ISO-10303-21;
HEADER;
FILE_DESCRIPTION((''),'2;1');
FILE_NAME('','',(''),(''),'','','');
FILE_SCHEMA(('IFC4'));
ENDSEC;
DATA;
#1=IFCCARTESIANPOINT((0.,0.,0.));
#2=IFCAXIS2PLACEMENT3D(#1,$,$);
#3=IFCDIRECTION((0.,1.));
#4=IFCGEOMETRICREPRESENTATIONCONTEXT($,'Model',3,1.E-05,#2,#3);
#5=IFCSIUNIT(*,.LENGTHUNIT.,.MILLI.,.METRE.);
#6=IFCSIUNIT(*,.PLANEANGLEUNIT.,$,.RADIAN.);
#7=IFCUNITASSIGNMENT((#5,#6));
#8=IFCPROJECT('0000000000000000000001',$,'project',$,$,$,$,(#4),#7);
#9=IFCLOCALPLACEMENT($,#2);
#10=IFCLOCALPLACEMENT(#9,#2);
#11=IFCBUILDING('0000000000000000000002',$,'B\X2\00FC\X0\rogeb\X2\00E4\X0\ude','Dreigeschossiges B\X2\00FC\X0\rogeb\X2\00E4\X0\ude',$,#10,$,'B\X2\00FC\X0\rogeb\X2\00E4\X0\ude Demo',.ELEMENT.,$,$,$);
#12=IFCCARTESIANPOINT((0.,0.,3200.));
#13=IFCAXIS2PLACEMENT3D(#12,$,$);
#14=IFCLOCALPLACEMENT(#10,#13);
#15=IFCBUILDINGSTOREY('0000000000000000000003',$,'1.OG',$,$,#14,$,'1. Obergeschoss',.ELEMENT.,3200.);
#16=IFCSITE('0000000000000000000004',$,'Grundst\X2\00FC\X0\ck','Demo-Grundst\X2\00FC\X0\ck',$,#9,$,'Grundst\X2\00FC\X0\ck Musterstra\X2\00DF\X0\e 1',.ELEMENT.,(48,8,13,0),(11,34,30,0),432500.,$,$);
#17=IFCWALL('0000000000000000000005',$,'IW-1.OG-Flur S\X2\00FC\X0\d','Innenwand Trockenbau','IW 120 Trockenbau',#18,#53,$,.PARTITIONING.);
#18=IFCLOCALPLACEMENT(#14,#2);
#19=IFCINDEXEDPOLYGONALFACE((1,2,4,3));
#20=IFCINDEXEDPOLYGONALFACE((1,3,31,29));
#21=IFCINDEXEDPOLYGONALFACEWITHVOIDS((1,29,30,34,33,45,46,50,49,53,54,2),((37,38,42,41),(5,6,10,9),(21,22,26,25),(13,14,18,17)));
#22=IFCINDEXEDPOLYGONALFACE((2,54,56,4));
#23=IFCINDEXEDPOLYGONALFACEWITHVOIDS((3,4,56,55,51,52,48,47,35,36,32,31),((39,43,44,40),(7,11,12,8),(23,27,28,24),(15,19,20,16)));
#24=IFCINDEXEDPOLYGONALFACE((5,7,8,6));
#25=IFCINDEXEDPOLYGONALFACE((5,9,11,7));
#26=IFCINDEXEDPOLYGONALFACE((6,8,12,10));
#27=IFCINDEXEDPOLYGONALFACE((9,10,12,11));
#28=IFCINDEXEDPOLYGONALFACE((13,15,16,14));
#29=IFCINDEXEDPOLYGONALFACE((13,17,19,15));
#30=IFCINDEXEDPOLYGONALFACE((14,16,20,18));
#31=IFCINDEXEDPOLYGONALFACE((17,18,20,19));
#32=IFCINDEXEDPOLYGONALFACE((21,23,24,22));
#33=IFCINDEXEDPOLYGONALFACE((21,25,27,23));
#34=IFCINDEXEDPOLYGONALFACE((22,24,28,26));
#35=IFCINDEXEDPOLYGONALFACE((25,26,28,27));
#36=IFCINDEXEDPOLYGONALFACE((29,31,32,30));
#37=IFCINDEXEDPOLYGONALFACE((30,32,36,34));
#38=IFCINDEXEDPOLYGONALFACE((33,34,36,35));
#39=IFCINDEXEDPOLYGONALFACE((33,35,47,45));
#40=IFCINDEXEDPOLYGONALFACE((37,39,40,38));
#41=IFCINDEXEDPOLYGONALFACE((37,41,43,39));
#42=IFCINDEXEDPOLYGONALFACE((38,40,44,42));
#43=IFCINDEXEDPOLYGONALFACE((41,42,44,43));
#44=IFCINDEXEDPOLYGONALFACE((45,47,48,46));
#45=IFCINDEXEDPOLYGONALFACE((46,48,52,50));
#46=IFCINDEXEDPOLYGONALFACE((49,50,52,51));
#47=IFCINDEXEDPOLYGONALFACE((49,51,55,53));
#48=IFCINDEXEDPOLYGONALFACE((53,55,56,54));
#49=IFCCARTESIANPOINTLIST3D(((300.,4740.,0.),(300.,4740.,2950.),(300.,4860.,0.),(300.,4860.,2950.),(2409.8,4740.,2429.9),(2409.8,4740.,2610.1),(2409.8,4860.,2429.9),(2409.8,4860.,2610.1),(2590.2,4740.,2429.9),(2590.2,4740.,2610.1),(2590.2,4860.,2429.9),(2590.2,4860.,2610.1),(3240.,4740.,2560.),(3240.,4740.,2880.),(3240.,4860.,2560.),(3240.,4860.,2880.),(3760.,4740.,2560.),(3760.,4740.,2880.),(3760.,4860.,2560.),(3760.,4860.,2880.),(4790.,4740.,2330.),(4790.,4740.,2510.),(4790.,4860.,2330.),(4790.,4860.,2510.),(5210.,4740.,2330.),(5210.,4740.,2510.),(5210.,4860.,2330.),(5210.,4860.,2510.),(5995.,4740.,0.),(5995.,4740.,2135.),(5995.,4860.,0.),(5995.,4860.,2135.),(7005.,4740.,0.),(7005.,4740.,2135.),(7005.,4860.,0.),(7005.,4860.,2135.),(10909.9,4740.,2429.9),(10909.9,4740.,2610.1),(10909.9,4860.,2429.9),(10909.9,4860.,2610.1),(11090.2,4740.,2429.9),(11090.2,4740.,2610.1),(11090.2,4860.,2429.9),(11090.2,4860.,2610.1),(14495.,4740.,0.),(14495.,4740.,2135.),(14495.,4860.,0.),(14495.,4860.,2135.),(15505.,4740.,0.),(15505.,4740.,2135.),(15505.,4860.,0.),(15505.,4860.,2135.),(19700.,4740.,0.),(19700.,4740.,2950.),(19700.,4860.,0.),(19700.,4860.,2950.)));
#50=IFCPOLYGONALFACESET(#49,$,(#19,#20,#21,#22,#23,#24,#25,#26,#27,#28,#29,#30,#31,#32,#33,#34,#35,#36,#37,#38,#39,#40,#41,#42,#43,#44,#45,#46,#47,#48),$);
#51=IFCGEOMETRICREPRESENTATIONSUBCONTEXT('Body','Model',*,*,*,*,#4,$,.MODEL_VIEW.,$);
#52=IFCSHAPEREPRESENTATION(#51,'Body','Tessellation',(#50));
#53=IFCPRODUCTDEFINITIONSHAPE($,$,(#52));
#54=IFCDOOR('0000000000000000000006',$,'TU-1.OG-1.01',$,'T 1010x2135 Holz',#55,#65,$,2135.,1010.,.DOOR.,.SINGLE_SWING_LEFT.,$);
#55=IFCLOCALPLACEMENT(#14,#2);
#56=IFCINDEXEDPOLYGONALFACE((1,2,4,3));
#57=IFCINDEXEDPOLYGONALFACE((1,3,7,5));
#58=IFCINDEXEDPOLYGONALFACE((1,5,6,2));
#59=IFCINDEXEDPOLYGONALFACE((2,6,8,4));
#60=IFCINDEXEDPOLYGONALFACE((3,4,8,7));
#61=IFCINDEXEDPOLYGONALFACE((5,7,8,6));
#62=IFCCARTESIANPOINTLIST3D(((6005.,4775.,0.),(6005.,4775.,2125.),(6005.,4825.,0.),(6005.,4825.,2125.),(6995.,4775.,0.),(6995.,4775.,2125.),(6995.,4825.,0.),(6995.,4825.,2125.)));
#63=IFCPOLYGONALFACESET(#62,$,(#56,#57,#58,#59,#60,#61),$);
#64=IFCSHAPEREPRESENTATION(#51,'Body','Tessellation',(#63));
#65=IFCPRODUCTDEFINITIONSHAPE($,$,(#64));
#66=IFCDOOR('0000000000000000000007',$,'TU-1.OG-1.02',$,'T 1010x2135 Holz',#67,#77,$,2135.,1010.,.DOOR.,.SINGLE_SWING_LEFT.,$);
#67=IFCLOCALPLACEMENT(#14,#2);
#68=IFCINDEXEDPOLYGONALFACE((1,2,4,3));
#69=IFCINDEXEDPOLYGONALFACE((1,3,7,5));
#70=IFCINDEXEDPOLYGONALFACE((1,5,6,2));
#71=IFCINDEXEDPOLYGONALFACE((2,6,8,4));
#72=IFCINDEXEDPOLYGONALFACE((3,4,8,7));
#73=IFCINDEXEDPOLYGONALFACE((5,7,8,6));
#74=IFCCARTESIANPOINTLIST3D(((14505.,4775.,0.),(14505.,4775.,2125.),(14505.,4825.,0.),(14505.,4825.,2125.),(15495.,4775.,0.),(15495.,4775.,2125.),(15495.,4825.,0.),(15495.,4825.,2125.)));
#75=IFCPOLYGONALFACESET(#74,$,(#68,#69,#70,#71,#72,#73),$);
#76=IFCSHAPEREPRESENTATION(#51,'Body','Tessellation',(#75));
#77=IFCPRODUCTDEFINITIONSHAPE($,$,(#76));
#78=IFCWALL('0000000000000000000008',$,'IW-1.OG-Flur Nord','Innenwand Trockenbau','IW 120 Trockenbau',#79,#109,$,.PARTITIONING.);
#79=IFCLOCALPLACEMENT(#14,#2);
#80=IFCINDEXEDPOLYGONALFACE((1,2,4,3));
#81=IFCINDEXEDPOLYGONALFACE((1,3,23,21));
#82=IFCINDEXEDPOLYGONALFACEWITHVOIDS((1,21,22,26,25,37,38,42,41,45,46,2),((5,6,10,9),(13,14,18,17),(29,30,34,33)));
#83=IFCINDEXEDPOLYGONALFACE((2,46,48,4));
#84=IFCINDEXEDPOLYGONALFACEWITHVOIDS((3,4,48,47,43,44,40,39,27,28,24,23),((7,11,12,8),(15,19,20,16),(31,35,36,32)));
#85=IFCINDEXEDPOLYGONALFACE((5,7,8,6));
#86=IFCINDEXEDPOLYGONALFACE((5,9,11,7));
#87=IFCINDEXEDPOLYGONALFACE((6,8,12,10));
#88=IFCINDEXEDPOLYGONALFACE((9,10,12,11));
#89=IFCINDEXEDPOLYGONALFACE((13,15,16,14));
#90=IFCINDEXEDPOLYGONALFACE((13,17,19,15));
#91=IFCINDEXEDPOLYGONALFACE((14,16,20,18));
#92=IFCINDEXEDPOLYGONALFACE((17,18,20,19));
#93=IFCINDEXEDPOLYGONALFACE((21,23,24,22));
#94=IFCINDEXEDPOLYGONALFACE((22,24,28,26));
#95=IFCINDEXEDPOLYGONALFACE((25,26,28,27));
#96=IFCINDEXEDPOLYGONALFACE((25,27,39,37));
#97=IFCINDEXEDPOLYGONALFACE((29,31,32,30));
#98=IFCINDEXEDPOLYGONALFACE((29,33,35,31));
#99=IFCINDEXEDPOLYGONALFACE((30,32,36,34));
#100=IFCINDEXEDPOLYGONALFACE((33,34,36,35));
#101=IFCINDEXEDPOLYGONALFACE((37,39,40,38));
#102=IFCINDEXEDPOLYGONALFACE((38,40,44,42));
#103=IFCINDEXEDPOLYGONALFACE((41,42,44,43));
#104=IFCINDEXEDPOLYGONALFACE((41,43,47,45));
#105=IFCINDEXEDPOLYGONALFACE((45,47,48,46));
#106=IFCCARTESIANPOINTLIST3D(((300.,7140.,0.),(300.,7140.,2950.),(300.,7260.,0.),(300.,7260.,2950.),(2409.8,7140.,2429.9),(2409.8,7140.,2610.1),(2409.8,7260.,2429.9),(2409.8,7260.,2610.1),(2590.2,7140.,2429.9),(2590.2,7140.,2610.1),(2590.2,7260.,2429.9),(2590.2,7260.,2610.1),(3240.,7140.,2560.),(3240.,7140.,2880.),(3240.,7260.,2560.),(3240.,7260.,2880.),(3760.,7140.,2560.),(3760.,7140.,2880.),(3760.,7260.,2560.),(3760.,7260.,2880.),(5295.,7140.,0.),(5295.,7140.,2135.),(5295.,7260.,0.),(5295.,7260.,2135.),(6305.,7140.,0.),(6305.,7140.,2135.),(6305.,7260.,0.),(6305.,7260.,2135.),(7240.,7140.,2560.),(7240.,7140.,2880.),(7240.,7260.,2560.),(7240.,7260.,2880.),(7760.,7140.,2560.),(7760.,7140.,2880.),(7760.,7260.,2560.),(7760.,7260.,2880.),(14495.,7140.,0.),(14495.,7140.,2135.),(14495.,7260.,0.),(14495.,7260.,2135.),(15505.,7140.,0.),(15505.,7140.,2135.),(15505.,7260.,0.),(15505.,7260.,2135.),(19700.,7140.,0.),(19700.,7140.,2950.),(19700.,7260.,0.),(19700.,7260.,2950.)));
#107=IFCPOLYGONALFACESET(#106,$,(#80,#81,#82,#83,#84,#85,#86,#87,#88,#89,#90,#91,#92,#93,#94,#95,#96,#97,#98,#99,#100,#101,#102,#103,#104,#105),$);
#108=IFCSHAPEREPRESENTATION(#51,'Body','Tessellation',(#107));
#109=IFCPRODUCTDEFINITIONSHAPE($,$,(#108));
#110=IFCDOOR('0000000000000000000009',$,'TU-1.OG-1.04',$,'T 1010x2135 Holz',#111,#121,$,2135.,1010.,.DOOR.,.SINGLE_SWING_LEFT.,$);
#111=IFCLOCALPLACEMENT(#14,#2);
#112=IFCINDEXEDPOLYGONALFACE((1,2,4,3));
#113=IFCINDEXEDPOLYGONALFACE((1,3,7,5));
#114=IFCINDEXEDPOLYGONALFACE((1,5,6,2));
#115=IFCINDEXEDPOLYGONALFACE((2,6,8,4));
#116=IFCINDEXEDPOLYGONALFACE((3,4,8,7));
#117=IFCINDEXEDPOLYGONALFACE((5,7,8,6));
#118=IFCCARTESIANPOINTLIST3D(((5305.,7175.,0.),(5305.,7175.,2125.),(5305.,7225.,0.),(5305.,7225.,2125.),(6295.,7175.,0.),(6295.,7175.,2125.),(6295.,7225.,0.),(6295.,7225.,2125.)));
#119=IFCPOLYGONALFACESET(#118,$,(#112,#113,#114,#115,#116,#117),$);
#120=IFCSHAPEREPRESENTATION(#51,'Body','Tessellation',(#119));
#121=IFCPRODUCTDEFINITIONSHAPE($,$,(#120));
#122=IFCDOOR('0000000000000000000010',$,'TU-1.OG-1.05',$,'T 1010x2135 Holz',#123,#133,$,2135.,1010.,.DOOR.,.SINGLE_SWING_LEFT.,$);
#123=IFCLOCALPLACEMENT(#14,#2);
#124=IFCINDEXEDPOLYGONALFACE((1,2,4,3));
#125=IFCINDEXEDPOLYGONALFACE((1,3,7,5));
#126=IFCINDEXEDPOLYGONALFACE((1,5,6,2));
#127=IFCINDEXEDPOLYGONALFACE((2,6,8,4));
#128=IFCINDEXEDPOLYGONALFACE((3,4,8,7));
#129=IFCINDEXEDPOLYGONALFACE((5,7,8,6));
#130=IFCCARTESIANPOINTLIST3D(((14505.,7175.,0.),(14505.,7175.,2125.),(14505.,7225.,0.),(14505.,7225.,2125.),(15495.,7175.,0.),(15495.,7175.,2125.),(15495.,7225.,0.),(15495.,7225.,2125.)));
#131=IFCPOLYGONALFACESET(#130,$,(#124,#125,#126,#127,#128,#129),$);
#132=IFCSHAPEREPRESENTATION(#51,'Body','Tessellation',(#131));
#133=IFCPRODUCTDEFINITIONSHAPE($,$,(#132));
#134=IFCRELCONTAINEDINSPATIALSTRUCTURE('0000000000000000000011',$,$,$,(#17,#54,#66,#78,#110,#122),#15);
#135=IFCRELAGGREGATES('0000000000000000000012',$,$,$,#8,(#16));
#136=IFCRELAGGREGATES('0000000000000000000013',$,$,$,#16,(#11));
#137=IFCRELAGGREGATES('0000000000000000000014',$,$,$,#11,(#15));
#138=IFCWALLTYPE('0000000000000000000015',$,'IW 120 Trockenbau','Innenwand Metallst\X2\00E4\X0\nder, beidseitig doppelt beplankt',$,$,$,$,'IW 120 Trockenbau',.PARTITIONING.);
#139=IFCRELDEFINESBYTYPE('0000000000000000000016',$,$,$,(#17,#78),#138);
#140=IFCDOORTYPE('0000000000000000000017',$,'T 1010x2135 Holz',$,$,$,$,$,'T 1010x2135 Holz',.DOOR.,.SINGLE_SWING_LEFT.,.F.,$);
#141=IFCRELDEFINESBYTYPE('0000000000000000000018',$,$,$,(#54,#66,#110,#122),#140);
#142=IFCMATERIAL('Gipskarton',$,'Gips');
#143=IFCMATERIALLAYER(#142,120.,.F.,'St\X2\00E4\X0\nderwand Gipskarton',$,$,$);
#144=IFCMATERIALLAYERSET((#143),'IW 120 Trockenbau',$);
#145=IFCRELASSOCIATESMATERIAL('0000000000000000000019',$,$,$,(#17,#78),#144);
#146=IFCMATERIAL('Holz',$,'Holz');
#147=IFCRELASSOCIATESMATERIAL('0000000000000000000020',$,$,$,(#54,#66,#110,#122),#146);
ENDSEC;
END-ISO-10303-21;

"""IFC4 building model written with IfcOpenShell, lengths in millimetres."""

from ifc_helpers import new_model, si_unit, direction, frame, frame_2d, origin, origin_2d, place, context, subcontext, project, spatial, rectangle, extrude, material, layer, layer_set, layer_usage, type_object, element, fill, save


model = new_model("IFC4")

# Units and contexts
model_context = context("Model", 3, precision=1e-05, world=origin(), true_north=direction((0.0, 1.0)))
body_context = subcontext(model_context, "Body", "Model", "MODEL_VIEW")
ifc_project = project(units=[si_unit("LENGTHUNIT", "METRE", prefix="MILLI"), si_unit("PLANEANGLEUNIT", "RADIAN")], contexts=[model_context])

# Site, building, storey
site_placement = place(None, origin())
site = spatial("IfcSite", under=ifc_project, at=site_placement, Name="Grundstück", Description="Demo-Grundstück", LongName="Grundstück Musterstraße 1", CompositionType="ELEMENT", RefLatitude=(48, 8, 13, 0), RefLongitude=(11, 34, 30, 0), RefElevation=432500.0)
building_placement = place(site_placement, origin())
building = spatial("IfcBuilding", under=site, at=building_placement, Name="Bürogebäude", Description="Dreigeschossiges Bürogebäude", LongName="Bürogebäude Demo", CompositionType="ELEMENT")
storey_placement = place(building_placement, frame((0.0, 0.0, 3200.0)))
storey = spatial("IfcBuildingStorey", under=building, at=storey_placement, Name="1.OG", LongName="1. Obergeschoss", CompositionType="ELEMENT", Elevation=3200.0)

# Walls, openings, doors
ifc_material_1 = material(Name="Gipskarton", Category="Gips")
ifc_layer_1 = layer(ifc_material_1, 120.0, ventilated=False, Name="Ständerwand Gipskarton")
ifc_layer_set_1 = layer_set([ifc_layer_1], Name="IW 120 Trockenbau")
ifc_layer_usage_1 = layer_usage(ifc_layer_set_1, "AXIS2", "POSITIVE", -60.0)
wall_type_1 = type_object("IfcWallType", Name="IW 120 Trockenbau", Description="Innenwand Metallständer, beidseitig doppelt beplankt", ElementType="IW 120 Trockenbau", PredefinedType="PARTITIONING")
wall_1_placement = place(storey_placement, frame((300.0, 4800.0, 0.0)))
wall_1 = element("IfcWall", 1, at=wall_1_placement, inside=storey, type_object=wall_type_1, material=ifc_layer_usage_1, Name="IW-1.OG-Flur Süd", Description="Innenwand Trockenbau", ObjectType="IW 120 Trockenbau", PredefinedType="PARTITIONING", context=body_context, shape_type="SweptSolid", body=[
    extrude(rectangle(XDim=19400.0, YDim=120.0, at=frame_2d((9700.0, 0.0))), origin(), (0.0, 0.0, 1.0), 2950.0),
])
opening_1_placement = place(wall_1_placement, frame((6200.0, 0.0, 0.0)))
opening_1 = element("IfcOpeningElement", 2, at=opening_1_placement, cuts=wall_1, PredefinedType="OPENING", context=body_context, shape_type="SweptSolid", body=[
    extrude(rectangle(XDim=1010.0, YDim=160.0, at=origin_2d()), frame((0.0, 0.0, -20.0)), (0.0, 0.0, 1.0), 2155.0),
])
opening_2_placement = place(wall_1_placement, frame((14700.0, 0.0, 0.0)))
opening_2 = element("IfcOpeningElement", 3, at=opening_2_placement, cuts=wall_1, PredefinedType="OPENING", context=body_context, shape_type="SweptSolid", body=[
    extrude(rectangle(XDim=1010.0, YDim=160.0, at=origin_2d()), frame((0.0, 0.0, -20.0)), (0.0, 0.0, 1.0), 2155.0),
])
opening_3_placement = place(wall_1_placement, frame((3200.0, 0.0, 2560.0)))
element("IfcOpeningElement", 4, at=opening_3_placement, cuts=wall_1, PredefinedType="OPENING", context=body_context, shape_type="SweptSolid", body=[
    extrude(rectangle(XDim=520.0, YDim=160.0, at=origin_2d()), origin(), (0.0, 0.0, 1.0), 320.0),
])
opening_4_placement = place(wall_1_placement, frame((2200.0, 0.0, 2429.8)))
element("IfcOpeningElement", 5, at=opening_4_placement, cuts=wall_1, PredefinedType="OPENING", context=body_context, shape_type="SweptSolid", body=[
    extrude(rectangle(XDim=180.3, YDim=160.0, at=origin_2d()), origin(), (0.0, 0.0, 1.0), 180.3),
])
opening_5_placement = place(wall_1_placement, frame((10700.0, 0.0, 2429.8)))
element("IfcOpeningElement", 6, at=opening_5_placement, cuts=wall_1, PredefinedType="OPENING", context=body_context, shape_type="SweptSolid", body=[
    extrude(rectangle(XDim=180.3, YDim=160.0, at=origin_2d()), origin(), (0.0, 0.0, 1.0), 180.3),
])
opening_6_placement = place(wall_1_placement, frame((4700.0, 0.0, 2330.0)))
element("IfcOpeningElement", 7, at=opening_6_placement, cuts=wall_1, PredefinedType="OPENING", context=body_context, shape_type="SweptSolid", body=[
    extrude(rectangle(XDim=420.0, YDim=160.0, at=origin_2d()), origin(), (0.0, 0.0, 1.0), 180.0),
])
ifc_material_2 = material(Name="Holz", Category="Holz")
door_type = type_object("IfcDoorType", Name="T 1010x2135 Holz", ElementType="T 1010x2135 Holz", OperationType="SINGLE_SWING_LEFT", ParameterTakesPrecedence=False, PredefinedType="DOOR")
door_1_placement = place(opening_1_placement, origin())
door_1 = element("IfcDoor", 8, at=door_1_placement, inside=storey, type_object=door_type, material=ifc_material_2, Name="TU-1.OG-1.01", ObjectType="T 1010x2135 Holz", OperationType="SINGLE_SWING_LEFT", OverallHeight=2135.0, OverallWidth=1010.0, PredefinedType="DOOR", context=body_context, shape_type="SweptSolid", body=[
    extrude(rectangle(XDim=990.0, YDim=50.0, at=origin_2d()), origin(), (0.0, 0.0, 1.0), 2125.0),
])
fill(opening_1, door_1)
door_2_placement = place(opening_2_placement, origin())
door_2 = element("IfcDoor", 9, at=door_2_placement, inside=storey, type_object=door_type, material=ifc_material_2, Name="TU-1.OG-1.02", ObjectType="T 1010x2135 Holz", OperationType="SINGLE_SWING_LEFT", OverallHeight=2135.0, OverallWidth=1010.0, PredefinedType="DOOR", context=body_context, shape_type="SweptSolid", body=[
    extrude(rectangle(XDim=990.0, YDim=50.0, at=origin_2d()), origin(), (0.0, 0.0, 1.0), 2125.0),
])
fill(opening_2, door_2)
wall_2_placement = place(storey_placement, frame((300.0, 7200.0, 0.0)))
wall_2 = element("IfcWall", 10, at=wall_2_placement, inside=storey, type_object=wall_type_1, material=ifc_layer_usage_1, Name="IW-1.OG-Flur Nord", Description="Innenwand Trockenbau", ObjectType="IW 120 Trockenbau", PredefinedType="PARTITIONING", context=body_context, shape_type="SweptSolid", body=[
    extrude(rectangle(XDim=19400.0, YDim=120.0, at=frame_2d((9700.0, 0.0))), origin(), (0.0, 0.0, 1.0), 2950.0),
])
opening_7_placement = place(wall_2_placement, frame((5500.0, 0.0, 0.0)))
opening_7 = element("IfcOpeningElement", 11, at=opening_7_placement, cuts=wall_2, PredefinedType="OPENING", context=body_context, shape_type="SweptSolid", body=[
    extrude(rectangle(XDim=1010.0, YDim=160.0, at=origin_2d()), frame((0.0, 0.0, -20.0)), (0.0, 0.0, 1.0), 2155.0),
])
opening_8_placement = place(wall_2_placement, frame((14700.0, 0.0, 0.0)))
opening_8 = element("IfcOpeningElement", 12, at=opening_8_placement, cuts=wall_2, PredefinedType="OPENING", context=body_context, shape_type="SweptSolid", body=[
    extrude(rectangle(XDim=1010.0, YDim=160.0, at=origin_2d()), frame((0.0, 0.0, -20.0)), (0.0, 0.0, 1.0), 2155.0),
])
opening_9_placement = place(wall_2_placement, frame((3200.0, 0.0, 2560.0)))
element("IfcOpeningElement", 13, at=opening_9_placement, cuts=wall_2, PredefinedType="OPENING", context=body_context, shape_type="SweptSolid", body=[
    extrude(rectangle(XDim=520.0, YDim=160.0, at=origin_2d()), origin(), (0.0, 0.0, 1.0), 320.0),
])
opening_10_placement = place(wall_2_placement, frame((2200.0, 0.0, 2429.8)))
element("IfcOpeningElement", 14, at=opening_10_placement, cuts=wall_2, PredefinedType="OPENING", context=body_context, shape_type="SweptSolid", body=[
    extrude(rectangle(XDim=180.3, YDim=160.0, at=origin_2d()), origin(), (0.0, 0.0, 1.0), 180.3),
])
opening_11_placement = place(wall_2_placement, frame((7200.0, 0.0, 2560.0)))
element("IfcOpeningElement", 15, at=opening_11_placement, cuts=wall_2, PredefinedType="OPENING", context=body_context, shape_type="SweptSolid", body=[
    extrude(rectangle(XDim=520.0, YDim=160.0, at=origin_2d()), origin(), (0.0, 0.0, 1.0), 320.0),
])
door_3_placement = place(opening_7_placement, origin())
door_3 = element("IfcDoor", 16, at=door_3_placement, inside=storey, type_object=door_type, material=ifc_material_2, Name="TU-1.OG-1.04", ObjectType="T 1010x2135 Holz", OperationType="SINGLE_SWING_LEFT", OverallHeight=2135.0, OverallWidth=1010.0, PredefinedType="DOOR", context=body_context, shape_type="SweptSolid", body=[
    extrude(rectangle(XDim=990.0, YDim=50.0, at=origin_2d()), origin(), (0.0, 0.0, 1.0), 2125.0),
])
fill(opening_7, door_3)
door_4_placement = place(opening_8_placement, origin())
door_4 = element("IfcDoor", 17, at=door_4_placement, inside=storey, type_object=door_type, material=ifc_material_2, Name="TU-1.OG-1.05", ObjectType="T 1010x2135 Holz", OperationType="SINGLE_SWING_LEFT", OverallHeight=2135.0, OverallWidth=1010.0, PredefinedType="DOOR", context=body_context, shape_type="SweptSolid", body=[
    extrude(rectangle(XDim=990.0, YDim=50.0, at=origin_2d()), origin(), (0.0, 0.0, 1.0), 2125.0),
])
fill(opening_8, door_4)

save(model, "model.ifc")
